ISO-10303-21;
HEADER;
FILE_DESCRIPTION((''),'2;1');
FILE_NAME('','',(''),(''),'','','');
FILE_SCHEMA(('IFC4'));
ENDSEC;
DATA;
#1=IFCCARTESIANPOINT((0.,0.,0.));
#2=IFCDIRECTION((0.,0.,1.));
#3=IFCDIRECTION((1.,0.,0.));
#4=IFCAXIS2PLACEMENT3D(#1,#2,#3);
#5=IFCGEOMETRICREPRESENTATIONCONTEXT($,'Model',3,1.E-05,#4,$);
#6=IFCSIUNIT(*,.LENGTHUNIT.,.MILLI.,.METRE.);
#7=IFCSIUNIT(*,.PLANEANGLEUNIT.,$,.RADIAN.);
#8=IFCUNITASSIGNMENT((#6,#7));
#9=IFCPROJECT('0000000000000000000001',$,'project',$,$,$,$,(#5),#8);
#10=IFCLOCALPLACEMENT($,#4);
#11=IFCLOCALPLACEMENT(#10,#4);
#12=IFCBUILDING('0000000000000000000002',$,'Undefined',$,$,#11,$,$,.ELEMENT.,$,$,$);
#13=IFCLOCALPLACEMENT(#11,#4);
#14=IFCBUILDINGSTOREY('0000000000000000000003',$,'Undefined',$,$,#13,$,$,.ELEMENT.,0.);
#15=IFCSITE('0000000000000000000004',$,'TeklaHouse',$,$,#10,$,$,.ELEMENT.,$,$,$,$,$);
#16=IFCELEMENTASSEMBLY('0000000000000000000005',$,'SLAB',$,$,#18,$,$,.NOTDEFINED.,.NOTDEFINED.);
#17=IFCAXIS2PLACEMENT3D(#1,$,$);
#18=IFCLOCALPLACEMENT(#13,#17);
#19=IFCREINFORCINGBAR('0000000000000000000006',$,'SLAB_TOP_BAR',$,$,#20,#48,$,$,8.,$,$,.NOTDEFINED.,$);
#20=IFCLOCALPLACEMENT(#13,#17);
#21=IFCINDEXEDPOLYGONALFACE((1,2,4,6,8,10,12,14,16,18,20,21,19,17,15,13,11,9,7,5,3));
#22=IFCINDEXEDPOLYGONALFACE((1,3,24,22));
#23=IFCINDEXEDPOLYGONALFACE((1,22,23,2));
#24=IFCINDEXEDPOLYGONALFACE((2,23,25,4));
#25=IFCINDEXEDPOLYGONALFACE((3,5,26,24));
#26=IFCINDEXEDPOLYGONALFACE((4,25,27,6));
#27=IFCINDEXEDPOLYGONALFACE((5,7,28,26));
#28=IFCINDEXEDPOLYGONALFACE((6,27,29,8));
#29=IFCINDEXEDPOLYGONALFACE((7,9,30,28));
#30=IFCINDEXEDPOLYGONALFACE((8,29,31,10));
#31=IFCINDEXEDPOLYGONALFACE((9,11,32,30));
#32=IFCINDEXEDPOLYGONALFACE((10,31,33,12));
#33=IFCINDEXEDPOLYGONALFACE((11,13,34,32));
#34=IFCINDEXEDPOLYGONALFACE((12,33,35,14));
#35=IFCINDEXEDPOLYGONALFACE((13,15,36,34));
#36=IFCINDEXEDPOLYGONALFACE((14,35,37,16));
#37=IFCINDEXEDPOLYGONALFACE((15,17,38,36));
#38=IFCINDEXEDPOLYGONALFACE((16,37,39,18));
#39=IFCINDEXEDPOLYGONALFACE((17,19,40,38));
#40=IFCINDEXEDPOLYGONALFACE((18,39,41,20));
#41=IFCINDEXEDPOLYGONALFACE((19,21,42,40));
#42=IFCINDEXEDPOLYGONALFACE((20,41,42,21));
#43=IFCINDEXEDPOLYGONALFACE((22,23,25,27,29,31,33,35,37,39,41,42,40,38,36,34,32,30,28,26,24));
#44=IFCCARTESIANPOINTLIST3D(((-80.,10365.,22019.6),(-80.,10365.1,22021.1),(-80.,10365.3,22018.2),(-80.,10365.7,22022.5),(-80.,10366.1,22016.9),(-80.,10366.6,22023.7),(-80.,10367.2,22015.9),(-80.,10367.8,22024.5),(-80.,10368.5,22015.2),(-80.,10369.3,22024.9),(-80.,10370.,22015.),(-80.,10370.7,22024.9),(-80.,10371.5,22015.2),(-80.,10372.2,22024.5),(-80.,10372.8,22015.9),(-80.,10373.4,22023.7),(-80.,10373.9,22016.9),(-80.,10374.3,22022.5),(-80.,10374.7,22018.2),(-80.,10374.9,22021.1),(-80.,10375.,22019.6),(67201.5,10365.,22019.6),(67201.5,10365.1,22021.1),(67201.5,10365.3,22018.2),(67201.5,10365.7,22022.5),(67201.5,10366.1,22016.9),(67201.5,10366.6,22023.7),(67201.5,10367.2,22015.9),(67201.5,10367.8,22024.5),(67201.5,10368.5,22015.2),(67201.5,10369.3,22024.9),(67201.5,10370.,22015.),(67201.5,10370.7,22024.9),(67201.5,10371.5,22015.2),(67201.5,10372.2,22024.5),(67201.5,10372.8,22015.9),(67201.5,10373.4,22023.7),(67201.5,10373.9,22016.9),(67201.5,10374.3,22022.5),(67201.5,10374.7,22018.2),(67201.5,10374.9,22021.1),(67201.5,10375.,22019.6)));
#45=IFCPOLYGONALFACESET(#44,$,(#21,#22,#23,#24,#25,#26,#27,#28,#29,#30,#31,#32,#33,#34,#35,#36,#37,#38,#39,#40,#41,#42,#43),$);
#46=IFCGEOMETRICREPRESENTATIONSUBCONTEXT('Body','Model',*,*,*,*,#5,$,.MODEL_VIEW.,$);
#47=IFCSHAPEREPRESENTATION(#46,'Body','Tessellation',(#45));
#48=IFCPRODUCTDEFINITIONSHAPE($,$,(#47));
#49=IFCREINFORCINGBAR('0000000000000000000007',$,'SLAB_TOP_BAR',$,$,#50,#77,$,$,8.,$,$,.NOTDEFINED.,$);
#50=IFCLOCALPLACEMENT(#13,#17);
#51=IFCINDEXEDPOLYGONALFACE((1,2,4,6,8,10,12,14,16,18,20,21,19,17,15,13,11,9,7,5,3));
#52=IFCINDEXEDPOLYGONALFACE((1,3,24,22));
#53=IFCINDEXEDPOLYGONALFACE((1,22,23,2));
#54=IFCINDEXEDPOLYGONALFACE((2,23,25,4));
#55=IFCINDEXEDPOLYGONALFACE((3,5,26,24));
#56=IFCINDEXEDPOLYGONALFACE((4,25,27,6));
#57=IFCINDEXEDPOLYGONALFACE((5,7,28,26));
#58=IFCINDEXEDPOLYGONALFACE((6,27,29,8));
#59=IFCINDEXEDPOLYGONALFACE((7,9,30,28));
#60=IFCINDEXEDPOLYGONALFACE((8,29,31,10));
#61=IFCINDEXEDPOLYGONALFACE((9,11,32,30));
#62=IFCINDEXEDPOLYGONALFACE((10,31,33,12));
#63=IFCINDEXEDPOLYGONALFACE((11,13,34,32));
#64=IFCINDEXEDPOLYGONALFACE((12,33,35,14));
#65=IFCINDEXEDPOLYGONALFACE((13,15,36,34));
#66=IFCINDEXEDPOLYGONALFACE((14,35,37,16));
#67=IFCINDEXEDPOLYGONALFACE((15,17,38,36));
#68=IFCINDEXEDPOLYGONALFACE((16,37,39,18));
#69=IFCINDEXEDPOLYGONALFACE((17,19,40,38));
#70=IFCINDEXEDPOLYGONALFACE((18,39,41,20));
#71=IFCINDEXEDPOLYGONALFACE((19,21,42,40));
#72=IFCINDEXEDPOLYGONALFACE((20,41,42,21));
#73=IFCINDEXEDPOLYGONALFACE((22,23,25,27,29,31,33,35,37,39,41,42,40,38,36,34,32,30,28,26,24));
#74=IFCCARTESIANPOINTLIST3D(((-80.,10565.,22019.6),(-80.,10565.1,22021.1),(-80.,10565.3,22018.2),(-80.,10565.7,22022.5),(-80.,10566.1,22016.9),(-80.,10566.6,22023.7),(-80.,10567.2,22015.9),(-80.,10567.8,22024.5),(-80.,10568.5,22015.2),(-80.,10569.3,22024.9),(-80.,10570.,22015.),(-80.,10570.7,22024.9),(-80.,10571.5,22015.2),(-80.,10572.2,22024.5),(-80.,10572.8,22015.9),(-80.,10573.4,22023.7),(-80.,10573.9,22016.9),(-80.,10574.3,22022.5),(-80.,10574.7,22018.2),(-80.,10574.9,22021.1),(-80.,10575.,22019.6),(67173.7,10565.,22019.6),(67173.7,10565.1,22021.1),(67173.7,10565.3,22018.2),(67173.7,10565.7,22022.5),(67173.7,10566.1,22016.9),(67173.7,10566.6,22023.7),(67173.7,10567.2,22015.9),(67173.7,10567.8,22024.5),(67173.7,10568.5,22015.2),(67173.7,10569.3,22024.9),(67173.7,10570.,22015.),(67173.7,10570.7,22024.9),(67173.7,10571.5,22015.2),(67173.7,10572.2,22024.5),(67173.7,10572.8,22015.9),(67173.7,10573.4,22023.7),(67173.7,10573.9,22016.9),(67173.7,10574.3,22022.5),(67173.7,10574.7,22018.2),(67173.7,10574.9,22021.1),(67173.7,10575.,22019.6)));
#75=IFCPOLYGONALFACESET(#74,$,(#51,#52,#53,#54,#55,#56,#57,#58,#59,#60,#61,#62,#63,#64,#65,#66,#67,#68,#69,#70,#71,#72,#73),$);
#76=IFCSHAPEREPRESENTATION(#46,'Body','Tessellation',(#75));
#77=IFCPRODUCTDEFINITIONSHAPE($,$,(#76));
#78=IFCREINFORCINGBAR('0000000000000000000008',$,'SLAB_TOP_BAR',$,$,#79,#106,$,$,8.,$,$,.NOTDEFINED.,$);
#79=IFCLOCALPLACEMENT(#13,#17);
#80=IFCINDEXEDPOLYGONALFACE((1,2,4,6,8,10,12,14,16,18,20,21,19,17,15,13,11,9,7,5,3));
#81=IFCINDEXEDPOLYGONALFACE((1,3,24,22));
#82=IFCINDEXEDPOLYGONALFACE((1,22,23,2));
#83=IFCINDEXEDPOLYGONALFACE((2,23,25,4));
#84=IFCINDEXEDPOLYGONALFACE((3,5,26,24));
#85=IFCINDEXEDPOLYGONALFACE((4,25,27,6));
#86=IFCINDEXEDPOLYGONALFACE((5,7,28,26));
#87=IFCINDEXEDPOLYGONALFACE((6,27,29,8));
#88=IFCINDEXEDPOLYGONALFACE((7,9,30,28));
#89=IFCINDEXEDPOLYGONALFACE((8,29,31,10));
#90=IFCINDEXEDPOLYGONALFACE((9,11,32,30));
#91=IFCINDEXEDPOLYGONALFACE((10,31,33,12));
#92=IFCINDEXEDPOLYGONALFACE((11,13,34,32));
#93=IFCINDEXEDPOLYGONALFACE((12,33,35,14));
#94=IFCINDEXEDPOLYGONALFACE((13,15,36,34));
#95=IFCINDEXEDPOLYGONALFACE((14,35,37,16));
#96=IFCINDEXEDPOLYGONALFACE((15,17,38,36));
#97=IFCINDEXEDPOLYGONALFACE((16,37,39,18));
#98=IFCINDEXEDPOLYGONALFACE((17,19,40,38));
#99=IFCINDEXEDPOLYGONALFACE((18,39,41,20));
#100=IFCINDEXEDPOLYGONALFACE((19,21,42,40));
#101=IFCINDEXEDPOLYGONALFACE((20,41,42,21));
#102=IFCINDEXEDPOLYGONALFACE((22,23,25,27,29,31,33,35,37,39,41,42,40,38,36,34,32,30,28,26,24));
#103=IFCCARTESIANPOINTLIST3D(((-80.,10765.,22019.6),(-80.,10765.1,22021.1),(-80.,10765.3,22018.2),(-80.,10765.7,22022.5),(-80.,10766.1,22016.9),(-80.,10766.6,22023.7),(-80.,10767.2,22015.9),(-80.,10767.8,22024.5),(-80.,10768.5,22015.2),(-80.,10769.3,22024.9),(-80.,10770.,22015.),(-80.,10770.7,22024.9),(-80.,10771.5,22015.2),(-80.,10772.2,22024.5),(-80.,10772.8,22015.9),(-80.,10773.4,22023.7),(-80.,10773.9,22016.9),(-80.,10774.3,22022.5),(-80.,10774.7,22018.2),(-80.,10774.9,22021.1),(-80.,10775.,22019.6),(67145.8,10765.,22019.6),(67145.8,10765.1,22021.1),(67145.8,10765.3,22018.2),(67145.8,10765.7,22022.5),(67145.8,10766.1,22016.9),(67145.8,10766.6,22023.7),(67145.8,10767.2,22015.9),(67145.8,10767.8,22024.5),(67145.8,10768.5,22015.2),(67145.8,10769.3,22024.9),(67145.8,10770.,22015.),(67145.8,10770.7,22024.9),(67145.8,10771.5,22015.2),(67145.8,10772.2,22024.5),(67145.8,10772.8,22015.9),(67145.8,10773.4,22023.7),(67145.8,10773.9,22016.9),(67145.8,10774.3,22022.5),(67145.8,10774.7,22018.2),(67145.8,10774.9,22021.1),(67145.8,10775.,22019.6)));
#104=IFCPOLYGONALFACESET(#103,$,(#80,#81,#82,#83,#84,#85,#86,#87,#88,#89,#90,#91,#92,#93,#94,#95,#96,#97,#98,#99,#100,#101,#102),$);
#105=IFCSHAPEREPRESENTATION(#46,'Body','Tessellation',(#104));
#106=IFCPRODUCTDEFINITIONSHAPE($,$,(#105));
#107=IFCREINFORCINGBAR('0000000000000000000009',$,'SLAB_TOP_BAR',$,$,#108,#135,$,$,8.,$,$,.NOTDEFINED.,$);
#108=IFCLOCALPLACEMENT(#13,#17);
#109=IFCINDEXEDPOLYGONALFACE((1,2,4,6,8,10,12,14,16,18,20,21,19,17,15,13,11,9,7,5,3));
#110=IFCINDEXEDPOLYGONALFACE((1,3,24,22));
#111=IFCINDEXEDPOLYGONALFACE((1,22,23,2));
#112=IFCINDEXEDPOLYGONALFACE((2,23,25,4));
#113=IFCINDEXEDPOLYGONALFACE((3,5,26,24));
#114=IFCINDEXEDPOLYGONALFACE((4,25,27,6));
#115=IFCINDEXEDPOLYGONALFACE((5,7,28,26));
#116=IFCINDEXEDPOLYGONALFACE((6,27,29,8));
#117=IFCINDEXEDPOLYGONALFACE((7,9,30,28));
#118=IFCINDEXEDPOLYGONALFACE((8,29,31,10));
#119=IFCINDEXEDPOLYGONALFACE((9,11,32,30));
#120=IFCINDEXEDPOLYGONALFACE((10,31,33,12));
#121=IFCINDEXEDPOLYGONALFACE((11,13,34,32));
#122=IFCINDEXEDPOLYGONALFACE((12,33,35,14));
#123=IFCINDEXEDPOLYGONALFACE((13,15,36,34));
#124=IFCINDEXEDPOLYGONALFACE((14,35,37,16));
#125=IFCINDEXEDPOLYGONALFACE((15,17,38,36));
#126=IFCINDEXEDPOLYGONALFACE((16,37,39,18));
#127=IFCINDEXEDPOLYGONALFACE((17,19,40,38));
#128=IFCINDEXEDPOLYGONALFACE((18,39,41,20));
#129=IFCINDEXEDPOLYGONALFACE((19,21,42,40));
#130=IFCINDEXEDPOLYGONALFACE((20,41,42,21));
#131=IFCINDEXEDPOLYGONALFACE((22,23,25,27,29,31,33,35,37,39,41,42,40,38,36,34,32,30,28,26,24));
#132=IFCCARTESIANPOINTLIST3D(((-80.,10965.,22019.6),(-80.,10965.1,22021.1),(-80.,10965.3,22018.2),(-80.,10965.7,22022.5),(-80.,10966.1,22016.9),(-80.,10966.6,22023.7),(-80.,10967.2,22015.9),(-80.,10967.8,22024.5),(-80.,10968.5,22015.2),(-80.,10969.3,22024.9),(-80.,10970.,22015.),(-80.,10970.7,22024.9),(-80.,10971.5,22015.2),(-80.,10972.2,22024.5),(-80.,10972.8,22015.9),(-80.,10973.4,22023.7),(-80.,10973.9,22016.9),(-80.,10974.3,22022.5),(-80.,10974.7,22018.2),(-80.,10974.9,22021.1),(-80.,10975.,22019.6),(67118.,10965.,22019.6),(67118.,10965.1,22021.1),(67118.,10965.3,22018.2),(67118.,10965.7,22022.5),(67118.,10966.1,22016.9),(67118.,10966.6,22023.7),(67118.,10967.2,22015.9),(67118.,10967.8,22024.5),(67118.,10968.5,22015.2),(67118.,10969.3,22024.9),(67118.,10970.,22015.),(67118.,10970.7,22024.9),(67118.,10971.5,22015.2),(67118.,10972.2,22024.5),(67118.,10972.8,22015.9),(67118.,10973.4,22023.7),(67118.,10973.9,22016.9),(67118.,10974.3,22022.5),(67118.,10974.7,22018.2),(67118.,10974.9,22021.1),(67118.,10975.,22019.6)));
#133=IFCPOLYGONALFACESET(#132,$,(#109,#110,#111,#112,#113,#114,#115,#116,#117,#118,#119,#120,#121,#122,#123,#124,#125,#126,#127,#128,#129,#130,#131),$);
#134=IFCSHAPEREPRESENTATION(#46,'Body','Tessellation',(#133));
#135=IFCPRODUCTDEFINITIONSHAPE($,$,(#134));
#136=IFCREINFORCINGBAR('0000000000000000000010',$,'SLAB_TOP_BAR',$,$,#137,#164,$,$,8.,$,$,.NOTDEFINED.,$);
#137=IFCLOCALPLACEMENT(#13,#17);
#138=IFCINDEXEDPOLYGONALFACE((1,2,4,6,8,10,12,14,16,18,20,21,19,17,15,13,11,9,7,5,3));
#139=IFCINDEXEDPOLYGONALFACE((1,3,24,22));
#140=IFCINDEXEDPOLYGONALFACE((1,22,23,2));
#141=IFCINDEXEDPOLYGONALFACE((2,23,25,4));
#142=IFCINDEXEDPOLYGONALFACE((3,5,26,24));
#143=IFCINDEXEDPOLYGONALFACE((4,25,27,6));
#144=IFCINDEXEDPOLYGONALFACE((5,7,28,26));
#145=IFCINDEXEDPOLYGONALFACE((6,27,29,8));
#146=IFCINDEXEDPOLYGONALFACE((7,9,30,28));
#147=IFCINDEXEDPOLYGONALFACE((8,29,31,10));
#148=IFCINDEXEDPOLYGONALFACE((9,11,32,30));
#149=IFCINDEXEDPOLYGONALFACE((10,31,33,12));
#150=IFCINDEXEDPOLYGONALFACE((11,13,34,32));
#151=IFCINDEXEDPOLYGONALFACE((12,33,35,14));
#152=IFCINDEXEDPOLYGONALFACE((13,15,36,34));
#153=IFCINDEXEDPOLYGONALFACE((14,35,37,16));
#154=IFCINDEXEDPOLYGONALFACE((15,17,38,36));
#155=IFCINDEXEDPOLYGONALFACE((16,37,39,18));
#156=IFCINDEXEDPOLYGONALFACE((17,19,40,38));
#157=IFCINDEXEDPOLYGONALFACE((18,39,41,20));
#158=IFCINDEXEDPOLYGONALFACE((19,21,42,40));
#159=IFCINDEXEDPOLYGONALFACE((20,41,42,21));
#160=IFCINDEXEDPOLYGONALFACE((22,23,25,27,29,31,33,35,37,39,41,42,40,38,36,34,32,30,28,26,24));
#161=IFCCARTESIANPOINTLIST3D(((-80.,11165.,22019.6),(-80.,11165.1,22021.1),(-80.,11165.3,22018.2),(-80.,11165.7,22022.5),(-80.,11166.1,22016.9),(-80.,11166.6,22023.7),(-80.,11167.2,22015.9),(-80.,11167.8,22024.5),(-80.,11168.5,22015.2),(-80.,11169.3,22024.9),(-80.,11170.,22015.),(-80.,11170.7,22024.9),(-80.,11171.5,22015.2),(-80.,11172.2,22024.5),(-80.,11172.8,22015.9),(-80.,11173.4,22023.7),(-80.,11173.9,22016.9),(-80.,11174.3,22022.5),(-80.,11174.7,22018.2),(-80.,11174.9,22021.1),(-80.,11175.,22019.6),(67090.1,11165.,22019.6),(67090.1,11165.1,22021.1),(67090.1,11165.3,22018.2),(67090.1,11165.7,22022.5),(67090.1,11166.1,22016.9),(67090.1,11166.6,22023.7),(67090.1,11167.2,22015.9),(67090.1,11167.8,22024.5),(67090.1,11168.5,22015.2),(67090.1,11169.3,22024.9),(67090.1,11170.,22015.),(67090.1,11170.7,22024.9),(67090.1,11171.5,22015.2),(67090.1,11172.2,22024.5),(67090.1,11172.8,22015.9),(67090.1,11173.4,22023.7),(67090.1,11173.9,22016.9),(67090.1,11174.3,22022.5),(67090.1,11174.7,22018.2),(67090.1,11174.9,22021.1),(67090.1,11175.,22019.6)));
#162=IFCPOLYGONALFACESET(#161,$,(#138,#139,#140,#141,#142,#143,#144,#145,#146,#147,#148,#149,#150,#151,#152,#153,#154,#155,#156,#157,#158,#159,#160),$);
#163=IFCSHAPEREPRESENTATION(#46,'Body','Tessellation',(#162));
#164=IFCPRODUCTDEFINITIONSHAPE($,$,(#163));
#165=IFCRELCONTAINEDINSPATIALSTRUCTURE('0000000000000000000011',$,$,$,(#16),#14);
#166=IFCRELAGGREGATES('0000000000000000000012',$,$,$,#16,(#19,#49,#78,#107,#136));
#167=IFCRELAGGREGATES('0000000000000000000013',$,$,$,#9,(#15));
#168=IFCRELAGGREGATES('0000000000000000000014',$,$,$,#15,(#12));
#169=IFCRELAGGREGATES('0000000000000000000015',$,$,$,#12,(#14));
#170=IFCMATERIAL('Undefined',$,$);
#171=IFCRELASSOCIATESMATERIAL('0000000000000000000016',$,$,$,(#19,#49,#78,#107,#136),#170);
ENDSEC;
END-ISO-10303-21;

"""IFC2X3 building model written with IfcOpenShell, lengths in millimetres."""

from ifc_helpers import new_model, entity, si_unit, frame, origin_with_axes, place, context, subcontext, project, spatial, source, transform, mapped, material, element, aggregate, save


model = new_model("IFC2X3")

# Units and contexts
model_context = context("Model", 3, precision=1e-05, world=origin_with_axes())
body_context = subcontext(model_context, "Body", "Model", "MODEL_VIEW")
ifc_project = project(units=[si_unit("LENGTHUNIT", "METRE", prefix="MILLI"), si_unit("PLANEANGLEUNIT", "RADIAN")], contexts=[model_context])

# Site, building, storey
site_placement = place(None, origin_with_axes())
site = spatial("IfcSite", under=ifc_project, at=site_placement, Name="TeklaHouse", CompositionType="ELEMENT")
building_placement = place(site_placement, origin_with_axes())
building = spatial("IfcBuilding", under=site, at=building_placement, Name="Undefined", CompositionType="ELEMENT")
storey_placement = place(building_placement, origin_with_axes())
storey = spatial("IfcBuildingStorey", under=building, at=storey_placement, Name="Undefined", CompositionType="ELEMENT", Elevation=0.0)

# Shared definitions
ifc_material_1 = material(Name="Undefined")

# Element assembly, reinforcing bars
assembly_1_placement = place(storey_placement, origin_with_axes())
assembly_1 = element("IfcElementAssembly", 1, at=assembly_1_placement, inside=storey, Name="SLAB", AssemblyPlace="NOTDEFINED", PredefinedType="NOTDEFINED")
shared_shape_1 = source(origin_with_axes(), body_context, "Body", "AdvancedSweptSolid", [
    entity("IfcSweptDiskSolid", entity("IfcTrimmedCurve", entity("IfcLine", entity("IfcCartesianPoint", [0.0, 0.0, 0.0]), entity("IfcVector", entity("IfcDirection", [1.0, 0.0, 0.0]), 1.0)), [entity("IfcParameterValue", 0.0)], [entity("IfcParameterValue", 67281.496942)], True, "PARAMETER"), 5.0, None, 0.0, 67281.5),
])
reinforcing_bar_1_placement = place(assembly_1_placement, frame((67201.5, 10370.0, 22020.0), z_axis=(0.0, 0.0, -1.0), x_axis=(-1.0, 0.0, 0.0)))
reinforcing_bar_1 = element("IfcReinforcingBar", 2, at=reinforcing_bar_1_placement, material=ifc_material_1, Name="SLAB_TOP_BAR", BarRole="NOTDEFINED", NominalDiameter=8.0, context=body_context, shape_type="MappedRepresentation", body=[
    mapped(shared_shape_1, transform((0.0, 0.0, 0.0))),
])
shared_shape_2 = source(origin_with_axes(), body_context, "Body", "AdvancedSweptSolid", [
    entity("IfcSweptDiskSolid", entity("IfcTrimmedCurve", entity("IfcLine", entity("IfcCartesianPoint", [0.0, 0.0, 0.0]), entity("IfcVector", entity("IfcDirection", [1.0, 0.0, 0.0]), 1.0)), [entity("IfcParameterValue", 0.0)], [entity("IfcParameterValue", 67253.650485)], True, "PARAMETER"), 5.0, None, 0.0, 67253.7),
])
reinforcing_bar_2_placement = place(assembly_1_placement, frame((67173.7, 10570.0, 22020.0), z_axis=(0.0, 0.0, -1.0), x_axis=(-1.0, 0.0, 0.0)))
reinforcing_bar_2 = element("IfcReinforcingBar", 3, at=reinforcing_bar_2_placement, material=ifc_material_1, Name="SLAB_TOP_BAR", BarRole="NOTDEFINED", NominalDiameter=8.0, context=body_context, shape_type="MappedRepresentation", body=[
    mapped(shared_shape_2, transform((0.0, 0.0, 0.0))),
])
shared_shape_3 = source(origin_with_axes(), body_context, "Body", "AdvancedSweptSolid", [
    entity("IfcSweptDiskSolid", entity("IfcTrimmedCurve", entity("IfcLine", entity("IfcCartesianPoint", [0.0, 0.0, 0.0]), entity("IfcVector", entity("IfcDirection", [1.0, 0.0, 0.0]), 1.0)), [entity("IfcParameterValue", 0.0)], [entity("IfcParameterValue", 67225.804028)], True, "PARAMETER"), 5.0, None, 0.0, 67225.8),
])
reinforcing_bar_3_placement = place(assembly_1_placement, frame((67145.8, 10770.0, 22020.0), z_axis=(0.0, 0.0, -1.0), x_axis=(-1.0, 0.0, 0.0)))
reinforcing_bar_3 = element("IfcReinforcingBar", 4, at=reinforcing_bar_3_placement, material=ifc_material_1, Name="SLAB_TOP_BAR", BarRole="NOTDEFINED", NominalDiameter=8.0, context=body_context, shape_type="MappedRepresentation", body=[
    mapped(shared_shape_3, transform((0.0, 0.0, 0.0))),
])
shared_shape_4 = source(origin_with_axes(), body_context, "Body", "AdvancedSweptSolid", [
    entity("IfcSweptDiskSolid", entity("IfcTrimmedCurve", entity("IfcLine", entity("IfcCartesianPoint", [0.0, 0.0, 0.0]), entity("IfcVector", entity("IfcDirection", [1.0, 0.0, 0.0]), 1.0)), [entity("IfcParameterValue", 0.0)], [entity("IfcParameterValue", 67197.957571)], True, "PARAMETER"), 5.0, None, 0.0, 67198.0),
])
reinforcing_bar_4_placement = place(assembly_1_placement, frame((67118.0, 10970.0, 22020.0), z_axis=(0.0, 0.0, -1.0), x_axis=(-1.0, 0.0, 0.0)))
reinforcing_bar_4 = element("IfcReinforcingBar", 5, at=reinforcing_bar_4_placement, material=ifc_material_1, Name="SLAB_TOP_BAR", BarRole="NOTDEFINED", NominalDiameter=8.0, context=body_context, shape_type="MappedRepresentation", body=[
    mapped(shared_shape_4, transform((0.0, 0.0, 0.0))),
])
shared_shape_5 = source(origin_with_axes(), body_context, "Body", "AdvancedSweptSolid", [
    entity("IfcSweptDiskSolid", entity("IfcTrimmedCurve", entity("IfcLine", entity("IfcCartesianPoint", [0.0, 0.0, 0.0]), entity("IfcVector", entity("IfcDirection", [1.0, 0.0, 0.0]), 1.0)), [entity("IfcParameterValue", 0.0)], [entity("IfcParameterValue", 67170.111114)], True, "PARAMETER"), 5.0, None, 0.0, 67170.1),
])
reinforcing_bar_5_placement = place(assembly_1_placement, frame((67090.1, 11170.0, 22020.0), z_axis=(0.0, 0.0, -1.0), x_axis=(-1.0, 0.0, 0.0)))
reinforcing_bar_5 = element("IfcReinforcingBar", 6, at=reinforcing_bar_5_placement, material=ifc_material_1, Name="SLAB_TOP_BAR", BarRole="NOTDEFINED", NominalDiameter=8.0, context=body_context, shape_type="MappedRepresentation", body=[
    mapped(shared_shape_5, transform((0.0, 0.0, 0.0))),
])
aggregate(assembly_1, [reinforcing_bar_1, reinforcing_bar_2, reinforcing_bar_3, reinforcing_bar_4, reinforcing_bar_5])

save(model, "model.ifc")
